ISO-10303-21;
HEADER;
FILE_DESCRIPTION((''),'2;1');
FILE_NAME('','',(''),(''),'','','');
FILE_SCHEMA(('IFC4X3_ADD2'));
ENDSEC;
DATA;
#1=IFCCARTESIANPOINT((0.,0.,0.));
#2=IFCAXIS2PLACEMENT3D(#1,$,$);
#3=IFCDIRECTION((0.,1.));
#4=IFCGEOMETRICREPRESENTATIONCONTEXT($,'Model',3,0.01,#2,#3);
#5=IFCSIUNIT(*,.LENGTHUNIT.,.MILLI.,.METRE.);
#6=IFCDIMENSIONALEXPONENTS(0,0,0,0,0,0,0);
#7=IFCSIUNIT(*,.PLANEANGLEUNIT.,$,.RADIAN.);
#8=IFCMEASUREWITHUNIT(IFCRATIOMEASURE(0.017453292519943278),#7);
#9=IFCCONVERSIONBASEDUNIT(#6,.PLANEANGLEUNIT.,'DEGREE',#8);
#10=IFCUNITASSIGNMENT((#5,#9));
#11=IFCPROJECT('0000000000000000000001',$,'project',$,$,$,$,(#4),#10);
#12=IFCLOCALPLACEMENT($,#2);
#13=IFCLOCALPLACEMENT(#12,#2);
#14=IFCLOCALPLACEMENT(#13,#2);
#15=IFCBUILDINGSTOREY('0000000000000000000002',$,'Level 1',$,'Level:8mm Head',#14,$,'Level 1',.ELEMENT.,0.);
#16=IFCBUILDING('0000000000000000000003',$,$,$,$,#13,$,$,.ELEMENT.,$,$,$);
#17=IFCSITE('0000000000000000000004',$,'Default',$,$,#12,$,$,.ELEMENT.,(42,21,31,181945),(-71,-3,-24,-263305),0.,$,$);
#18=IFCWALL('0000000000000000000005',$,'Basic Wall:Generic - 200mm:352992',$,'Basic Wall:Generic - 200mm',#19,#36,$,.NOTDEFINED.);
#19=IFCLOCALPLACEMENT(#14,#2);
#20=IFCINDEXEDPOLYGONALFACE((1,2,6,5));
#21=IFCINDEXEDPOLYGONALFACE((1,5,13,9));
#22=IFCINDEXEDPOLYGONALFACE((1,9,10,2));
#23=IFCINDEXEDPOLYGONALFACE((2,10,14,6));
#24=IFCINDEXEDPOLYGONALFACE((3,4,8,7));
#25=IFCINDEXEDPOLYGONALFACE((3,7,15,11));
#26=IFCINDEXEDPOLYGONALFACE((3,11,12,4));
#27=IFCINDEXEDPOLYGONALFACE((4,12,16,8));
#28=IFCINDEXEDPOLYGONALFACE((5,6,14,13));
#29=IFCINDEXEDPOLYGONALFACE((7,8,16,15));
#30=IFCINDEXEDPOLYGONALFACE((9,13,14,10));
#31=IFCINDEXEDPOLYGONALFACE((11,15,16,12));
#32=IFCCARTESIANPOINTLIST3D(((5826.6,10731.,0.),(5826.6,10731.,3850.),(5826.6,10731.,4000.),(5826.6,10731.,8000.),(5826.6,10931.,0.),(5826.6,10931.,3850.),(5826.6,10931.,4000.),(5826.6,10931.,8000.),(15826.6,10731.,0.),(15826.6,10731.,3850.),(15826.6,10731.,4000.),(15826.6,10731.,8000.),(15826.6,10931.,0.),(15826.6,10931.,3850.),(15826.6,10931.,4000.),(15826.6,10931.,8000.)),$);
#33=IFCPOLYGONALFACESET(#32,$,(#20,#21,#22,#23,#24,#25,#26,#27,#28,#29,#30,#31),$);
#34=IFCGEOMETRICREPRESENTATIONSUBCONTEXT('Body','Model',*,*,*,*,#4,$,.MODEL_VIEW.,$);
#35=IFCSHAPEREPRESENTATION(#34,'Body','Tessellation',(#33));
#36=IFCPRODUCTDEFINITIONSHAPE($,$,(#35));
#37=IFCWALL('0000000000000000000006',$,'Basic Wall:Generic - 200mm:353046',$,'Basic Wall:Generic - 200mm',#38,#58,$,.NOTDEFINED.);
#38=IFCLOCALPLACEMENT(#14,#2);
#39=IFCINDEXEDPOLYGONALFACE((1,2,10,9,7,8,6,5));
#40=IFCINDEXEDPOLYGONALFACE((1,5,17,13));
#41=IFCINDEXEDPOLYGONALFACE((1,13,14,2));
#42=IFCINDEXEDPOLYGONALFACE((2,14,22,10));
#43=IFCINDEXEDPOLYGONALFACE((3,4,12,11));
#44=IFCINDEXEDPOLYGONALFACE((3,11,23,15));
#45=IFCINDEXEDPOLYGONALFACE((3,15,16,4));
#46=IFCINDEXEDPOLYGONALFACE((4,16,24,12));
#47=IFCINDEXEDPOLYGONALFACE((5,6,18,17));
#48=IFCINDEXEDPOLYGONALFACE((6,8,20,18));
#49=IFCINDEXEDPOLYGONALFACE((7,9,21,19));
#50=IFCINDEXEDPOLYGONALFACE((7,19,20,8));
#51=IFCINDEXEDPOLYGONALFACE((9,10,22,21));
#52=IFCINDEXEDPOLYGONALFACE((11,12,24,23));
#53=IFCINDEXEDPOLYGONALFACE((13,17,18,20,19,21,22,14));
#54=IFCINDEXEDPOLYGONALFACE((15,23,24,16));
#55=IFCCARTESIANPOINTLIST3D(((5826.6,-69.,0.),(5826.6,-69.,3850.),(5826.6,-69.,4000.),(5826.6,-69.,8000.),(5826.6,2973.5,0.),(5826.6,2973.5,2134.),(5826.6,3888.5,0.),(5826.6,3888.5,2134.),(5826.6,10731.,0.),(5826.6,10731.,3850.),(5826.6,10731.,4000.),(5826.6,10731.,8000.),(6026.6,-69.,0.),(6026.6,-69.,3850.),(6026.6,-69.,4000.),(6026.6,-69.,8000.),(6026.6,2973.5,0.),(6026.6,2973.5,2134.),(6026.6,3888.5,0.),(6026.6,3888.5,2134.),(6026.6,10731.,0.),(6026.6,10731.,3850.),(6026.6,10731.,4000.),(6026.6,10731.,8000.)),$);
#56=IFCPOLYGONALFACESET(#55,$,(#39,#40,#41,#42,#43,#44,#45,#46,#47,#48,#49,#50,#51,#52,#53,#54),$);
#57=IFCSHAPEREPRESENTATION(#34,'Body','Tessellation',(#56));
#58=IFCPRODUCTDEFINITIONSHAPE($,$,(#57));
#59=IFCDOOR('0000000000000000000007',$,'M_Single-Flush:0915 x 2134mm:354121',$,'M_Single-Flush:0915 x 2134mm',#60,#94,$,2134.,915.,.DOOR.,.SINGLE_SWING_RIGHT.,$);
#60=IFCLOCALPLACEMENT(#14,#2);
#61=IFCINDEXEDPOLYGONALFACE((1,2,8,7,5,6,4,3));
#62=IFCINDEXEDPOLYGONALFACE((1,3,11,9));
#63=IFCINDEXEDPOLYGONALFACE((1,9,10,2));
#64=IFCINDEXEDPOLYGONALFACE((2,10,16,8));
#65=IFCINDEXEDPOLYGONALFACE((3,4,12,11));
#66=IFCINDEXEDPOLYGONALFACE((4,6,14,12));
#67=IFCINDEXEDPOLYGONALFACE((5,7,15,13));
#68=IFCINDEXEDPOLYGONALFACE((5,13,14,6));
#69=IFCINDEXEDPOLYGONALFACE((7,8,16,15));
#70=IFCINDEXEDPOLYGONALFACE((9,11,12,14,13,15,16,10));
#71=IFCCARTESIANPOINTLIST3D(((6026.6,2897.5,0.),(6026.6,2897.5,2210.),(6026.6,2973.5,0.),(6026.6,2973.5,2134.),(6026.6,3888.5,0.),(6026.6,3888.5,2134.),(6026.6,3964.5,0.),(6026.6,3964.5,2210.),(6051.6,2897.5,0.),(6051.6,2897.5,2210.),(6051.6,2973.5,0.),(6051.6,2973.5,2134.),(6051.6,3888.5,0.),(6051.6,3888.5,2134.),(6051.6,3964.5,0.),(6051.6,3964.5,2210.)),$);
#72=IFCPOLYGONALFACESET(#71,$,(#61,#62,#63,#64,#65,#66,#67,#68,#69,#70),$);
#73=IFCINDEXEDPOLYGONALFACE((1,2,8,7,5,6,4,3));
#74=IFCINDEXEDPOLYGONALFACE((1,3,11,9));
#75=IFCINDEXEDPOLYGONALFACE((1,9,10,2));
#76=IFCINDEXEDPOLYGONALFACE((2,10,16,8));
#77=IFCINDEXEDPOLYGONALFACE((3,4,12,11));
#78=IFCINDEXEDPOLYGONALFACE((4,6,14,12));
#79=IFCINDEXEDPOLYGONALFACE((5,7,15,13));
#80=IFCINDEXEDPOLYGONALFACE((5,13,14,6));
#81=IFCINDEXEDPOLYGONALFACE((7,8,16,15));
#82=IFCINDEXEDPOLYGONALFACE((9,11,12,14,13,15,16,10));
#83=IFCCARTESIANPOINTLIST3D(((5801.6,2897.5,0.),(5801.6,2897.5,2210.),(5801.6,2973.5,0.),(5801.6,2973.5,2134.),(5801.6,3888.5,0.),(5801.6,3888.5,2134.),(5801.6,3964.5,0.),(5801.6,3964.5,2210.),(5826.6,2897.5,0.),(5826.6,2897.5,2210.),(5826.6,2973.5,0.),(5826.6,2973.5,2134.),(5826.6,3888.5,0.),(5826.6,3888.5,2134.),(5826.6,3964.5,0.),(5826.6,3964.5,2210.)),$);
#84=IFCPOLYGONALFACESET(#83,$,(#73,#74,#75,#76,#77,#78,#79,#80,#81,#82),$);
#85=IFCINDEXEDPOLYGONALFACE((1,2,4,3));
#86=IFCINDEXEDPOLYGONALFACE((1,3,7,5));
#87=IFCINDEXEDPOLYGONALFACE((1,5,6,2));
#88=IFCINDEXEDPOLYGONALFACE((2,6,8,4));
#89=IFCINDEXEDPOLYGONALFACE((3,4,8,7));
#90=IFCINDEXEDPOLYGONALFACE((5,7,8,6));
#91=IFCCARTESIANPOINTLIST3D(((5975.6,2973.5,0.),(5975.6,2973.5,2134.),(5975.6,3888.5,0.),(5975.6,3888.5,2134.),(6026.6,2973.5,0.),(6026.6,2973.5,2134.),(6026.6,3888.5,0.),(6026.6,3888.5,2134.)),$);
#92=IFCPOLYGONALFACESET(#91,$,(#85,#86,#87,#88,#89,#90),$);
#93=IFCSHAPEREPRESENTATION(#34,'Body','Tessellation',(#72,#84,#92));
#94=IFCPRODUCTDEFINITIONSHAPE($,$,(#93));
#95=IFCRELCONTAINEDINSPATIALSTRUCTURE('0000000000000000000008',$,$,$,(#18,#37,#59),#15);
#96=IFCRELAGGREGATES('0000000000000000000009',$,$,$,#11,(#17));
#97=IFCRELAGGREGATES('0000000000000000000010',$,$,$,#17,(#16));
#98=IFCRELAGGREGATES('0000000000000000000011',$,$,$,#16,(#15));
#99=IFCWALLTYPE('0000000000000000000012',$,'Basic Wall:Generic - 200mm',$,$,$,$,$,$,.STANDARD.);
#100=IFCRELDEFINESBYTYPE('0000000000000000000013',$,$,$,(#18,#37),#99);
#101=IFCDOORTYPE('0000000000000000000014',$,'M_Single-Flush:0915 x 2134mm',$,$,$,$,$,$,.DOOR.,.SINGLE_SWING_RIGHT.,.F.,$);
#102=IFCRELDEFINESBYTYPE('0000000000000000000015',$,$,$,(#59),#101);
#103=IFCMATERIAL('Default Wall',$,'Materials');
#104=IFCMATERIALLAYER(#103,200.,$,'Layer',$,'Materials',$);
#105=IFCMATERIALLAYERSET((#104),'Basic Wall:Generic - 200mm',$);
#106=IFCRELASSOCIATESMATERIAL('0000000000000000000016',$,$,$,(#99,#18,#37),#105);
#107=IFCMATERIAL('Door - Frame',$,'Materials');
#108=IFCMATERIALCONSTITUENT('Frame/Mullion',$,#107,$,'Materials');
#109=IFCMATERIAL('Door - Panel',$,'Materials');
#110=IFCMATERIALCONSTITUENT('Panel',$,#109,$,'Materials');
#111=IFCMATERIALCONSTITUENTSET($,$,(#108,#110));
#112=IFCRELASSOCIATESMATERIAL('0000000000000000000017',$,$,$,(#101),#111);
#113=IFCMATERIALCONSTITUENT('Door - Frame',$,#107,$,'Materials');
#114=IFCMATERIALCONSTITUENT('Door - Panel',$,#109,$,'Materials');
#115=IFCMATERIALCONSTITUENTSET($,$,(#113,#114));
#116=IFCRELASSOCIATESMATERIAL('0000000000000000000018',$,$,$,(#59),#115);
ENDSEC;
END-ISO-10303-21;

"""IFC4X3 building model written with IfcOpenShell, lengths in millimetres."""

from ifc_helpers import new_model, entity, si_unit, converted_unit, direction, frame, frame_2d, origin, place, context, subcontext, project, spatial, polyline, rectangle, outline, extrude, source, transform, mapped, material, layer, layer_set, constituent, constituent_set, type_object, type_shapes, element, fill, save


model = new_model("IFC4X3")

# Units and contexts
model_context = context("Model", 3, precision=0.01, world=origin(), true_north=direction((0.0, 1.0)))
body_context = subcontext(model_context, "Body", "Model", "MODEL_VIEW")
ifc_project = project(units=[si_unit("LENGTHUNIT", "METRE", prefix="MILLI"), converted_unit("PLANEANGLEUNIT", "DEGREE", entity("IfcRatioMeasure", 0.017453292519943278), si_unit("PLANEANGLEUNIT", "RADIAN"), dimensions=[0, 0, 0, 0, 0, 0, 0])], contexts=[model_context])

# Site, building, storey
site_placement = place(None, origin())
site = spatial("IfcSite", under=ifc_project, at=site_placement, Name="Default", CompositionType="ELEMENT", RefLatitude=(42, 21, 31, 181945), RefLongitude=(-71, -3, -24, -263305), RefElevation=0.0)
building_placement = place(site_placement, origin())
building = spatial("IfcBuilding", under=site, at=building_placement, CompositionType="ELEMENT")
storey_placement = place(building_placement, origin())
storey = spatial("IfcBuildingStorey", under=building, at=storey_placement, Name="Level 1", ObjectType="Level:8mm Head", LongName="Level 1", CompositionType="ELEMENT", Elevation=0.0)

# Shared definitions
ifc_material_1 = material(Name="Default Wall", Category="Materials")
ifc_layer_1 = layer(ifc_material_1, 200.0, Name="Layer", Category="Materials")
ifc_layer_set_1 = layer_set([ifc_layer_1], Name="Basic Wall:Generic - 200mm")
wall_type = type_object("IfcWallType", Name="Basic Wall:Generic - 200mm", PredefinedType="STANDARD", material=ifc_layer_set_1)
ifc_material_2 = material(Name="Door - Frame", Category="Materials")
ifc_material_3 = material(Name="Door - Panel", Category="Materials")
ifc_constituent_1 = constituent(ifc_material_2, Name="Frame/Mullion", Category="Materials")
ifc_constituent_2 = constituent(ifc_material_3, Name="Panel", Category="Materials")
ifc_constituent_set_1 = constituent_set(constituents=[ifc_constituent_1, ifc_constituent_2])
door_type = type_object("IfcDoorType", Name="M_Single-Flush:0915 x 2134mm", OperationType="SINGLE_SWING_RIGHT", ParameterTakesPrecedence=False, PredefinedType="DOOR", material=ifc_constituent_set_1)
shared_shape = source(origin(), body_context, "Body", "SweptSolid", [
    extrude(outline(polyline([(-533.5, -1124.0), (533.5, -1124.0), (533.5, 1086.0), (457.5, 1086.0), (457.5, -1048.0), (-457.5, -1048.0), (-457.5, 1086.0), (-533.5, 1086.0), (-533.5, -1124.0)])), frame((457.5, 200.0, 1086.0), z_axis=(0.0, 1.0, 0.0), x_axis=(1.0, 0.0, 0.0)), (0.0, 0.0, 1.0), 25.0),
    extrude(outline(polyline([(-1124.0, -533.5), (1086.0, -533.5), (1086.0, -457.5), (-1048.0, -457.5), (-1048.0, 457.5), (1086.0, 457.5), (1086.0, 533.5), (-1124.0, 533.5), (-1124.0, -533.5)])), frame((457.5, -25.0, 1086.0), z_axis=(0.0, 1.0, 0.0), x_axis=(0.0, 0.0, -1.0)), (0.0, 0.0, 1.0), 25.0),
    extrude(rectangle(XDim=51.0, YDim=915.0, at=frame_2d((0.0, 0.0), x_axis=(1.0, 0.0))), frame((457.5, 174.5, 0.0), z_axis=(0.0, 0.0, 1.0), x_axis=(0.0, 1.0, 0.0)), (0.0, 0.0, 1.0), 2134.0),
])
type_shapes(door_type, [shared_shape])

# Wall, opening
wall_1_placement = place(storey_placement, frame((15826.6, 10831.0, 0.0), z_axis=(0.0, 0.0, 1.0), x_axis=(-1.0, 0.0, 0.0)))
wall_1 = element("IfcWall", 1, at=wall_1_placement, inside=storey, type_object=wall_type, material=ifc_layer_set_1, Name="Basic Wall:Generic - 200mm:352992", ObjectType="Basic Wall:Generic - 200mm", PredefinedType="NOTDEFINED", context=body_context, shape_type="SweptSolid", body=[
    extrude(rectangle(XDim=10000.0, YDim=200.0, at=frame_2d((5000.0, 0.0), x_axis=(-1.0, 0.0))), origin(), (0.0, 0.0, 1.0), 8000.0),
])
opening_1_placement = place(storey_placement, frame((15826.6, 10831.0, 0.0), z_axis=(0.0, 0.0, 1.0), x_axis=(-1.0, 0.0, 0.0)))
element("IfcOpeningElement", 2, at=opening_1_placement, cuts=wall_1, PredefinedType="OPENING", context=body_context, shape_type="SweptSolid", body=[
    extrude(rectangle(XDim=10000.0, YDim=200.0, at=frame_2d((-914.3, -42.9), x_axis=(1.0, 0.0))), frame((5914.3, 42.9, 3850.0)), (0.0, 0.0, 1.0), 150.0),
])

# Wall, openings, door
wall_2_placement = place(storey_placement, frame((5926.6, 10731.0, 0.0), z_axis=(0.0, 0.0, 1.0), x_axis=(0.0, -1.0, 0.0)))
wall_2 = element("IfcWall", 3, at=wall_2_placement, inside=storey, type_object=wall_type, material=ifc_layer_set_1, Name="Basic Wall:Generic - 200mm:353046", ObjectType="Basic Wall:Generic - 200mm", PredefinedType="NOTDEFINED", context=body_context, shape_type="SweptSolid", body=[
    extrude(rectangle(XDim=10800.0, YDim=200.0, at=frame_2d((5400.0, 0.0), x_axis=(-1.0, 0.0))), origin(), (0.0, 0.0, 1.0), 8000.0),
])
opening_2_placement = place(storey_placement, frame((5926.6, 10731.0, 0.0), z_axis=(0.0, 0.0, 1.0), x_axis=(0.0, -1.0, 0.0)))
element("IfcOpeningElement", 4, at=opening_2_placement, cuts=wall_2, PredefinedType="OPENING", context=body_context, shape_type="SweptSolid", body=[
    extrude(rectangle(XDim=10800.0, YDim=200.0, at=frame_2d((566.7, -33.3), x_axis=(1.0, 0.0))), frame((4833.3, 33.3, 3850.0)), (0.0, 0.0, 1.0), 150.0),
])
opening_3_placement = place(wall_2_placement, frame((6842.5, -100.0, 0.0)))
opening_3 = element("IfcOpeningElement", 5, at=opening_3_placement, cuts=wall_2, PredefinedType="OPENING", context=body_context, shape_type="SweptSolid", body=[
    extrude(rectangle(XDim=915.0, YDim=2134.0, at=frame_2d((1067.0, 457.5), x_axis=(0.0, 1.0))), frame((0.0, 0.0, 0.0), z_axis=(0.0, 1.0, 0.0), x_axis=(0.0, 0.0, 1.0)), (0.0, 0.0, 1.0), 200.0),
])
ifc_constituent_3 = constituent(ifc_material_2, Name="Door - Frame", Category="Materials")
ifc_constituent_4 = constituent(ifc_material_3, Name="Door - Panel", Category="Materials")
ifc_constituent_set_2 = constituent_set(constituents=[ifc_constituent_3, ifc_constituent_4])
door_1_placement = place(opening_3_placement, origin())
door_1 = element("IfcDoor", 6, at=door_1_placement, inside=storey, type_object=door_type, material=ifc_constituent_set_2, Name="M_Single-Flush:0915 x 2134mm:354121", ObjectType="M_Single-Flush:0915 x 2134mm", OperationType="SINGLE_SWING_RIGHT", OverallHeight=2134.0, OverallWidth=915.0, PredefinedType="DOOR", context=body_context, shape_type="MappedRepresentation", body=[
    mapped(shared_shape, transform((0.0, 0.0, 0.0), scale=1.0)),
])
fill(opening_3, door_1)

save(model, "model.ifc")
